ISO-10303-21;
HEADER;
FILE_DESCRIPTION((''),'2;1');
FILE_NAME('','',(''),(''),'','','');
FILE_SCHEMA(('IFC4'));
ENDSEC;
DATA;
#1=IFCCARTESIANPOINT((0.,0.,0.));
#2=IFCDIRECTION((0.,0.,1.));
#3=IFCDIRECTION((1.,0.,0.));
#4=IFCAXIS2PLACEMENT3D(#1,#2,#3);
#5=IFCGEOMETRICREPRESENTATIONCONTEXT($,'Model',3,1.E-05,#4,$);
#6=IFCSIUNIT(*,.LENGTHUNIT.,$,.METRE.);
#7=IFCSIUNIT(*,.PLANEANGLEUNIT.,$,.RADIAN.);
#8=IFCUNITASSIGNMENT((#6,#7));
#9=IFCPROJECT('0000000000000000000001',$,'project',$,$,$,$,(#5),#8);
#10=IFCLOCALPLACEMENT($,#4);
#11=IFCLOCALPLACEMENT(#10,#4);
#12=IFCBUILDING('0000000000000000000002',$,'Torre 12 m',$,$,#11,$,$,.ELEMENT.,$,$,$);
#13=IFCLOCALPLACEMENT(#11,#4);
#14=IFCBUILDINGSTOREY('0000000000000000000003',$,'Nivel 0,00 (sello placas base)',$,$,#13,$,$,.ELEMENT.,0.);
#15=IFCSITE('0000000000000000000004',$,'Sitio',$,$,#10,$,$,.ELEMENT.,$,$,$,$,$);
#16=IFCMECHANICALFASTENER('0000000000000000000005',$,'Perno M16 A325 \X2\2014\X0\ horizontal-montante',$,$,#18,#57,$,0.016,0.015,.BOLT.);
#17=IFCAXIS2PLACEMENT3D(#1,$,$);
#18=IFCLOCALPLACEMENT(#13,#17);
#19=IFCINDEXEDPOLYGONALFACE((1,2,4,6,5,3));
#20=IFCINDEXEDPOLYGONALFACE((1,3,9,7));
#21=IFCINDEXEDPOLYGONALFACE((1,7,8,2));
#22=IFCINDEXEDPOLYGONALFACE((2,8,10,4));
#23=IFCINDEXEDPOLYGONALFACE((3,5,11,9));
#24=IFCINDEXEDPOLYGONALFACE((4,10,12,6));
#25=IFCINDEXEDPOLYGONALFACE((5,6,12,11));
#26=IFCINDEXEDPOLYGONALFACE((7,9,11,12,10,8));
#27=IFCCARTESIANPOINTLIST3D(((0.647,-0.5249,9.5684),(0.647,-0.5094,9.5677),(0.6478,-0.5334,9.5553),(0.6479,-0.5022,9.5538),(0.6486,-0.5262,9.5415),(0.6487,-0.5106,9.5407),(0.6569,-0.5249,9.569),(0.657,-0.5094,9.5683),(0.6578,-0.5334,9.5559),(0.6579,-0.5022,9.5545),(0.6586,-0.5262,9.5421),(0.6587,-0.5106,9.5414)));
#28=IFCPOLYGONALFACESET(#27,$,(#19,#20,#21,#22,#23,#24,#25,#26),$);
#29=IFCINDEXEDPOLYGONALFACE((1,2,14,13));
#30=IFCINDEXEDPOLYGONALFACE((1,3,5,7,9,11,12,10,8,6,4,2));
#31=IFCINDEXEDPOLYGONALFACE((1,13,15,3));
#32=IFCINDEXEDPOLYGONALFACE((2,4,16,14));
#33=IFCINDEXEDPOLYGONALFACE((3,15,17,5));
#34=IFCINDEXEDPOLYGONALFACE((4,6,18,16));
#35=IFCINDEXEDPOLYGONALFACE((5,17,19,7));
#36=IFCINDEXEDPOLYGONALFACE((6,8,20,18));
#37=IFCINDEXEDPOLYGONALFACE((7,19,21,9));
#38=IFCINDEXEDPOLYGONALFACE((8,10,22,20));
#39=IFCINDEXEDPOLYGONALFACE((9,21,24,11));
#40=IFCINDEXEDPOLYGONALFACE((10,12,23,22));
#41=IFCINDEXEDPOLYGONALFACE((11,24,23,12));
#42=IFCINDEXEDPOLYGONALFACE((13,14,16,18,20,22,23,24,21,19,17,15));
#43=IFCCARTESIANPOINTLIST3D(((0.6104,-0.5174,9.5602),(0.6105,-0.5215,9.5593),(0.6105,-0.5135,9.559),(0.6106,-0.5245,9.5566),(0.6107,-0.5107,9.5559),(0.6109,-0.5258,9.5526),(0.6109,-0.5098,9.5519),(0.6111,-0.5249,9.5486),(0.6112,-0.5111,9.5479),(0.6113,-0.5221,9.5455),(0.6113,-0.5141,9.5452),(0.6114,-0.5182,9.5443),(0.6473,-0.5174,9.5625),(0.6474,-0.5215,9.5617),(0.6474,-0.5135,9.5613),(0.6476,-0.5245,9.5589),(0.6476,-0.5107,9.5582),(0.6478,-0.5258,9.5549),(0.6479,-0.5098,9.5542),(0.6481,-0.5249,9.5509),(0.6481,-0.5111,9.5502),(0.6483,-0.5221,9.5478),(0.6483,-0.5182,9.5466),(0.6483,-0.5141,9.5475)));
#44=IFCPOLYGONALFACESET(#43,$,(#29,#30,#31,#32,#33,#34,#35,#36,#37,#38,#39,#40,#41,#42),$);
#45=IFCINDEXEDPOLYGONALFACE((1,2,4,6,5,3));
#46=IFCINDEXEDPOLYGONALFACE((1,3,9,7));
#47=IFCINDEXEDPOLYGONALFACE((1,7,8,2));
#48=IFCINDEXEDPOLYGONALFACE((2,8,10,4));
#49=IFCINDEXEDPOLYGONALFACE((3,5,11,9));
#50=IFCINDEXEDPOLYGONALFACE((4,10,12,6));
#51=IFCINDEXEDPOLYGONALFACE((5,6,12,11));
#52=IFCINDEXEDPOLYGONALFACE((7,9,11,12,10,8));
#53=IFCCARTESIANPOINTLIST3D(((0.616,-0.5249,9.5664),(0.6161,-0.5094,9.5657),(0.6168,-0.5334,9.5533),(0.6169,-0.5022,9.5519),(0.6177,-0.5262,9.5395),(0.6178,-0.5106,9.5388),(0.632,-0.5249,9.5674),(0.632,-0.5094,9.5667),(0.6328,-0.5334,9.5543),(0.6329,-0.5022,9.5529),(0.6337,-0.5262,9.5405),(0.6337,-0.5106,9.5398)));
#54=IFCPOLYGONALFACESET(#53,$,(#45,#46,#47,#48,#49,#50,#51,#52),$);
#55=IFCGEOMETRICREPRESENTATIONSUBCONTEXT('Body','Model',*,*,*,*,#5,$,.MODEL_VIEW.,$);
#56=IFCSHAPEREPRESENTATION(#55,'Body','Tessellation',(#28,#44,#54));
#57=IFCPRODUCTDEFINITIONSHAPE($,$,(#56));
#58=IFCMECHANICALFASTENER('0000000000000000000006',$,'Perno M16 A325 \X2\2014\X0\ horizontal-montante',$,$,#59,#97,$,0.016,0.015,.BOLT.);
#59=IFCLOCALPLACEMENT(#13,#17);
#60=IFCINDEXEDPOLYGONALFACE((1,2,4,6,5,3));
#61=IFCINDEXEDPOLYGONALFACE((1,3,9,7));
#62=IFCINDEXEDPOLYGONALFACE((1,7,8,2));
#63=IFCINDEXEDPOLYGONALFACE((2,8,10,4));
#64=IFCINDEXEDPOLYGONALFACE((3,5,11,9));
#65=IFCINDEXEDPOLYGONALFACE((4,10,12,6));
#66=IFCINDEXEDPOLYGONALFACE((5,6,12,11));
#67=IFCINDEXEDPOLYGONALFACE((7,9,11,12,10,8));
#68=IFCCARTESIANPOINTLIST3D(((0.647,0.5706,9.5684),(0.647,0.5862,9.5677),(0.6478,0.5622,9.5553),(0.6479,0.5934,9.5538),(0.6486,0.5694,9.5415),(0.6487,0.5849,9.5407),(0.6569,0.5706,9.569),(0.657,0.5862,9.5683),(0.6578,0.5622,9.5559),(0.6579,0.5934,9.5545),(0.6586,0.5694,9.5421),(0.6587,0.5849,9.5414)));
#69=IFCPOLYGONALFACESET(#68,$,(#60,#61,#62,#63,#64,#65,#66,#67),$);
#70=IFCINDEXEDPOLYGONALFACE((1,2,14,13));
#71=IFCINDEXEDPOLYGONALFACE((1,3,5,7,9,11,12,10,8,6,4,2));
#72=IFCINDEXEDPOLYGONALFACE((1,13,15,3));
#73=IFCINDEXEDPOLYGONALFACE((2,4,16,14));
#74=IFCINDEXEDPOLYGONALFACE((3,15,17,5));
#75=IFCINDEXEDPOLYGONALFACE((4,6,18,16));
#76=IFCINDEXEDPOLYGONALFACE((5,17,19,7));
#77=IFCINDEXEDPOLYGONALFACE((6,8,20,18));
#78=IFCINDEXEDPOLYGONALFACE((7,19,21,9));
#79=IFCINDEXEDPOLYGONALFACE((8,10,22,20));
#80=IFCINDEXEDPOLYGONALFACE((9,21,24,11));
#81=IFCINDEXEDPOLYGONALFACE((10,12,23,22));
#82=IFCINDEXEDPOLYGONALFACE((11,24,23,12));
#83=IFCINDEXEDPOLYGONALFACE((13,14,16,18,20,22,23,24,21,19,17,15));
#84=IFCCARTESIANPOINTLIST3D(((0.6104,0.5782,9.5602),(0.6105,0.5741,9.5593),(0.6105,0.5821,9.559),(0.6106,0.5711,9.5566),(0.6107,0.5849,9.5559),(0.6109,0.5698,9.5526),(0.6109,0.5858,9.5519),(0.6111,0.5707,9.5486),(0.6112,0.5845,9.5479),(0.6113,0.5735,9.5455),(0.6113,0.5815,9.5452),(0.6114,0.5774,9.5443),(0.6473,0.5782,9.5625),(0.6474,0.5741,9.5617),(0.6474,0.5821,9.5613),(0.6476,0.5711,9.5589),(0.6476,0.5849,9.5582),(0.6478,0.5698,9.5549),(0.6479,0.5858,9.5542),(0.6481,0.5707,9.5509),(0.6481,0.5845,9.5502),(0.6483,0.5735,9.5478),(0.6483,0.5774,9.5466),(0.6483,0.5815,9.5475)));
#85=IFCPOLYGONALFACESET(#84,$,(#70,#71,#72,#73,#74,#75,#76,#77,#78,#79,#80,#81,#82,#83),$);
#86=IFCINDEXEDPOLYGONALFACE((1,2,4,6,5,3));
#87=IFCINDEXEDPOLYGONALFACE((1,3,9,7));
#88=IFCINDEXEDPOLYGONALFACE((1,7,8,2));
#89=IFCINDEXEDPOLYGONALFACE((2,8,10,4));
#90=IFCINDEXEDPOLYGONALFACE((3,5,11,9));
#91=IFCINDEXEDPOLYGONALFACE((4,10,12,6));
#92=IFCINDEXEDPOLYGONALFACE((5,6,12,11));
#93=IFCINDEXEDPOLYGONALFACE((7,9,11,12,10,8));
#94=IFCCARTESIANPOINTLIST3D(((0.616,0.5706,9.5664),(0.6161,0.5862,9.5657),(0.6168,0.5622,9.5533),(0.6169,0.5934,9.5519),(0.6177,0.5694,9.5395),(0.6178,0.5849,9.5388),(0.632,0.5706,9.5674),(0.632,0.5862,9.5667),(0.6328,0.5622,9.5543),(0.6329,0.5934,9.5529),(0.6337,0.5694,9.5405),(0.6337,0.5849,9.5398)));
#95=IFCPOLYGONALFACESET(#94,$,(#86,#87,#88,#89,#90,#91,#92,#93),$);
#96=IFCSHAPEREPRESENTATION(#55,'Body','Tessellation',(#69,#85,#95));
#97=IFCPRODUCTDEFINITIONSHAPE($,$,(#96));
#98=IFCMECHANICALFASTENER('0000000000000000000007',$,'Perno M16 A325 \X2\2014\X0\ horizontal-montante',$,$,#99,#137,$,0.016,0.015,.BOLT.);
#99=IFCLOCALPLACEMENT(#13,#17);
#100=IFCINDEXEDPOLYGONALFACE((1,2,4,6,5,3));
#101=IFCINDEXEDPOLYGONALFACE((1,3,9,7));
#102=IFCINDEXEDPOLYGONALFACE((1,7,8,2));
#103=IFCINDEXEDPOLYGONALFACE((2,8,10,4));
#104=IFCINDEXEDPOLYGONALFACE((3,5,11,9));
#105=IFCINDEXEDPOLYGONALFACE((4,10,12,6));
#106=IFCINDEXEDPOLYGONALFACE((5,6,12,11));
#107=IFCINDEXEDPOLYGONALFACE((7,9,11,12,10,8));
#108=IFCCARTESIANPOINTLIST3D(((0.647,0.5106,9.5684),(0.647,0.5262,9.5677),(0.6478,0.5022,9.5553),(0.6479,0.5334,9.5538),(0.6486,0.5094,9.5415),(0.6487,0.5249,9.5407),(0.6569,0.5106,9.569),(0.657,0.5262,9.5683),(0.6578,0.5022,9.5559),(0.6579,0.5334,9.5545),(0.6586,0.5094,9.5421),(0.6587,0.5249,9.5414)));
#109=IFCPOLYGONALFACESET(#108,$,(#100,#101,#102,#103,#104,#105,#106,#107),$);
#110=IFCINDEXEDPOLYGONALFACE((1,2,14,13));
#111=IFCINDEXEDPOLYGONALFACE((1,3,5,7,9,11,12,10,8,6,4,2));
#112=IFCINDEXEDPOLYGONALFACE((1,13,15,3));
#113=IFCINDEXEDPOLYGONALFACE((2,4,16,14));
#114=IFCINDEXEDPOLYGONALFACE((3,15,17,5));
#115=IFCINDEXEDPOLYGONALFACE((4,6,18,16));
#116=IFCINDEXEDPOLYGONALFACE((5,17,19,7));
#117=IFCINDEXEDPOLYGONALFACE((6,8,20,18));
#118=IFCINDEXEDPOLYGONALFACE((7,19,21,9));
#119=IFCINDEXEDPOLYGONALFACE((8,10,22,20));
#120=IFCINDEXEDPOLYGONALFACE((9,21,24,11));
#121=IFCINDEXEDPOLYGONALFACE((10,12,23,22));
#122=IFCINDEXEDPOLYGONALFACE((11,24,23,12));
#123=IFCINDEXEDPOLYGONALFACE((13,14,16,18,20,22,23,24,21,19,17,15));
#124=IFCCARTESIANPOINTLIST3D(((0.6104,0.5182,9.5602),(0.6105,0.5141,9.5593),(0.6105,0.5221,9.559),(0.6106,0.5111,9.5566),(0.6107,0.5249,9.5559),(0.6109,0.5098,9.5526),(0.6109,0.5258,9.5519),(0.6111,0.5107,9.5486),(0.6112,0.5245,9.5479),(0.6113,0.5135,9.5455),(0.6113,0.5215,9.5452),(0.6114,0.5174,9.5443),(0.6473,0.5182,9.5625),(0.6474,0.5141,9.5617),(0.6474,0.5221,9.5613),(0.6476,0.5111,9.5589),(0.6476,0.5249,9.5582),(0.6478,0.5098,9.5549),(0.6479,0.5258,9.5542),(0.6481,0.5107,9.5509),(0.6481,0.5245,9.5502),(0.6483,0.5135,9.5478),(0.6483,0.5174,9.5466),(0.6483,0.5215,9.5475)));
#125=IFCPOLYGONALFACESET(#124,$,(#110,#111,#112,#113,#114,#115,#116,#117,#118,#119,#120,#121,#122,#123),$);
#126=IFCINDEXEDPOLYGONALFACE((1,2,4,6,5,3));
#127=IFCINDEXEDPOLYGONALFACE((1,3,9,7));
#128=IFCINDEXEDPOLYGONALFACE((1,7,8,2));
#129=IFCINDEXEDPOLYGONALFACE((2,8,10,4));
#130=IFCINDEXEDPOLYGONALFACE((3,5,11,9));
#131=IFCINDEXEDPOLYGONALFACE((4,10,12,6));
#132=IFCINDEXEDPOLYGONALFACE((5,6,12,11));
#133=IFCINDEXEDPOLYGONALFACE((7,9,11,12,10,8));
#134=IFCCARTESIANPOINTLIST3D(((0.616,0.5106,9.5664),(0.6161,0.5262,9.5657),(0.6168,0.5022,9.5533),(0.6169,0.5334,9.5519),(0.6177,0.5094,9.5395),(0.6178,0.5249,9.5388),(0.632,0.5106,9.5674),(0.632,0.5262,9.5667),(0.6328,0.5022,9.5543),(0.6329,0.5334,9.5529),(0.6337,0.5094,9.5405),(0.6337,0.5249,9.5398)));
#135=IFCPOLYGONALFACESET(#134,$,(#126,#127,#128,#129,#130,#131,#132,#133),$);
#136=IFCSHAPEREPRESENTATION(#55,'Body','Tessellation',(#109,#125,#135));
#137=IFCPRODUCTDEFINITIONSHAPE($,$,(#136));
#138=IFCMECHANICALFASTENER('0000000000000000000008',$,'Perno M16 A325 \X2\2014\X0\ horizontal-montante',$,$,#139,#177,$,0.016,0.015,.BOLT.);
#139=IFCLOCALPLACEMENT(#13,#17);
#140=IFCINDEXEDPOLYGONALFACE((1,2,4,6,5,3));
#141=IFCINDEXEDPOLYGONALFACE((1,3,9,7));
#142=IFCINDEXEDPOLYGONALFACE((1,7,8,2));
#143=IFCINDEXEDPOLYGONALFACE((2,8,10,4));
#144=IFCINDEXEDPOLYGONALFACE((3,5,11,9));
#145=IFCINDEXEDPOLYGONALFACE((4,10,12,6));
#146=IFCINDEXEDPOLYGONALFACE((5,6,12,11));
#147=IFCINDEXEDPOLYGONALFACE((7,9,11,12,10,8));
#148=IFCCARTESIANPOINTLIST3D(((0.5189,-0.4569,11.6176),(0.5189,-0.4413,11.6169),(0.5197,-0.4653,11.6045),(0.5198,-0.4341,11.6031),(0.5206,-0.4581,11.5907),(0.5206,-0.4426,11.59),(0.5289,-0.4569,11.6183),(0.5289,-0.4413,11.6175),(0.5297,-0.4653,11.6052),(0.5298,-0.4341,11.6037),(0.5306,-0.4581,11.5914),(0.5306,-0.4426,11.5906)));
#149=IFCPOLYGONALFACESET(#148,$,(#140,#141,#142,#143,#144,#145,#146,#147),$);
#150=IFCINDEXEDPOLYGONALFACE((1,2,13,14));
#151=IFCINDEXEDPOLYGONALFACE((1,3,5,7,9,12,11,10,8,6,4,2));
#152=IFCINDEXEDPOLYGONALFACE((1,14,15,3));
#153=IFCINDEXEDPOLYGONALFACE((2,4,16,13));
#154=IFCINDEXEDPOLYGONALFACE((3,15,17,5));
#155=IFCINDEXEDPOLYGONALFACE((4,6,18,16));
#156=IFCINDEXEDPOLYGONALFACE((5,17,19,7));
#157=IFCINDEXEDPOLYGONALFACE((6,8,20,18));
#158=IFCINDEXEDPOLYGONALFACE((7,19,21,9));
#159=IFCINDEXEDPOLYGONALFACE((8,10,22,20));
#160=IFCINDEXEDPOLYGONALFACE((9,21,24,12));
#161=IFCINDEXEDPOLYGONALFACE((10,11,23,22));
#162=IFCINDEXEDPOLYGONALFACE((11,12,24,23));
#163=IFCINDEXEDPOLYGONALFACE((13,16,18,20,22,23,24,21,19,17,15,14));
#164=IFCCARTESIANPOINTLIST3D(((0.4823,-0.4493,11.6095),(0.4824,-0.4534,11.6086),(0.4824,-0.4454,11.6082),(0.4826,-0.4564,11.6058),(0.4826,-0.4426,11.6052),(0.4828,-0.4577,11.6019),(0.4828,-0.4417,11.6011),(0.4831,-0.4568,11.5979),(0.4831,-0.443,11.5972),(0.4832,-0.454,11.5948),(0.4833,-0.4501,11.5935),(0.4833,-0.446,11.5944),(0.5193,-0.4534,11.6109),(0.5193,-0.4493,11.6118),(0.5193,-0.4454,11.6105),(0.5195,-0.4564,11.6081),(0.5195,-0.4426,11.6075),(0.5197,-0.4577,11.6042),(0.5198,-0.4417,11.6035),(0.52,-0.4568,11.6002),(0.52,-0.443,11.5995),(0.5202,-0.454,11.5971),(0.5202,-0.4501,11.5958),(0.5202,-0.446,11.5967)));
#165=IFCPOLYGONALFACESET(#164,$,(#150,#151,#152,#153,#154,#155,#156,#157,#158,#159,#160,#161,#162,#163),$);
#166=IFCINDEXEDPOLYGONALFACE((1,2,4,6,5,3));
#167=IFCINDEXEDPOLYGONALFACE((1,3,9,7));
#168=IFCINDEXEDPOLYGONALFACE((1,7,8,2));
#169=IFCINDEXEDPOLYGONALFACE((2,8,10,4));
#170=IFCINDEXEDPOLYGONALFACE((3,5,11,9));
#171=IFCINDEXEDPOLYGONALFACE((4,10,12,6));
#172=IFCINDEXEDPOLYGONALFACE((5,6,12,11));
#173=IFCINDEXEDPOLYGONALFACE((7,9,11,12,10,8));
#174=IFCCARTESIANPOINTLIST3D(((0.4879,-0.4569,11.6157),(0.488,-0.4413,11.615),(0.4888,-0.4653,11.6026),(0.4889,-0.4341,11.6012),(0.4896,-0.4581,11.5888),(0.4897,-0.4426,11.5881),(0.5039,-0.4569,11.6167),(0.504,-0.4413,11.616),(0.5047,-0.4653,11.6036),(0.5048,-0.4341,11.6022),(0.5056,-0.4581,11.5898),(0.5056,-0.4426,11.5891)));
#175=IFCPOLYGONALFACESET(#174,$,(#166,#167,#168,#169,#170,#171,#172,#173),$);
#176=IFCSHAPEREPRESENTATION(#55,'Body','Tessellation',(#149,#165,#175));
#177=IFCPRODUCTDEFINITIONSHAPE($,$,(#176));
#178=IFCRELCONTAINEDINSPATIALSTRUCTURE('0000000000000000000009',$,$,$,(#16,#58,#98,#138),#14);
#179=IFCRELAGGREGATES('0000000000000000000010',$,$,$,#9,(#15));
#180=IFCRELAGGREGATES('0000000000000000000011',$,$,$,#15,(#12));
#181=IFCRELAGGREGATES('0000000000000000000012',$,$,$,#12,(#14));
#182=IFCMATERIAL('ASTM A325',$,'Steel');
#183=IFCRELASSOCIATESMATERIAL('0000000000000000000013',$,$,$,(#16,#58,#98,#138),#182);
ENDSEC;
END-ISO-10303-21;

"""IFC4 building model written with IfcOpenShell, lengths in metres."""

from ifc_helpers import new_model, si_unit, frame, origin_with_axes, place, context, subcontext, project, spatial, polyline, outline, extrude, material, element, save


model = new_model("IFC4")

# Units and contexts
model_context = context("Model", 3, precision=1e-05, world=origin_with_axes())
body_context = subcontext(model_context, "Body", "Model", "MODEL_VIEW")
ifc_project = project(units=[si_unit("LENGTHUNIT", "METRE"), si_unit("PLANEANGLEUNIT", "RADIAN")], contexts=[model_context])

# Site, building, storey
site_placement = place(None, origin_with_axes())
site = spatial("IfcSite", under=ifc_project, at=site_placement, Name="Sitio", CompositionType="ELEMENT")
building_placement = place(site_placement, origin_with_axes())
building = spatial("IfcBuilding", under=site, at=building_placement, Name="Torre 12 m", CompositionType="ELEMENT")
storey_placement = place(building_placement, origin_with_axes())
storey = spatial("IfcBuildingStorey", under=building, at=storey_placement, Name="Nivel 0,00 (sello placas base)", CompositionType="ELEMENT", Elevation=0.0)

# Shared definitions
placement = place(storey_placement, origin_with_axes())

# Mechanical fasteners
ifc_material_1 = material(Name="ASTM A325", Category="Steel")
element("IfcMechanicalFastener", 1, at=placement, inside=storey, material=ifc_material_1, Name="Perno M16 A325 — horizontal-montante", NominalDiameter=0.016, NominalLength=0.015, PredefinedType="BOLT", context=body_context, shape_type="SweptSolid", body=[
    extrude(outline(polyline([(0.0135, 0.0078), (0.0, 0.0156), (-0.0135, 0.0078), (-0.0135, -0.0078), (0.0, -0.0156), (0.0135, -0.0078), (0.0135, 0.0078)])), frame((0.6578, -0.5178, 9.5552), z_axis=(-0.998053, 0.0, -0.062378), x_axis=(0.033672, 0.841794, -0.538748)), (0.0, 0.0, 1.0), 0.01),
    extrude(outline(polyline([(0.008, 0.0), (0.0069, 0.004), (0.004, 0.0069), (0.0, 0.008), (-0.004, 0.0069), (-0.0069, 0.004), (-0.008, 0.0), (-0.0069, -0.004), (-0.004, -0.0069), (0.0, -0.008), (0.004, -0.0069), (0.0069, -0.004), (0.008, 0.0)])), frame((0.6478, -0.5178, 9.5546), z_axis=(-0.998053, 0.0, -0.062378), x_axis=(0.033672, 0.841794, -0.538748)), (0.0, 0.0, 1.0), 0.037),
    extrude(outline(polyline([(0.0135, 0.0078), (0.0, 0.0156), (-0.0135, 0.0078), (-0.0135, -0.0078), (0.0, -0.0156), (0.0135, -0.0078), (0.0135, 0.0078)])), frame((0.6329, -0.5178, 9.5536), z_axis=(-0.998053, 0.0, -0.062378), x_axis=(0.033672, 0.841794, -0.538748)), (0.0, 0.0, 1.0), 0.016),
])
element("IfcMechanicalFastener", 2, at=placement, inside=storey, material=ifc_material_1, Name="Perno M16 A325 — horizontal-montante", NominalDiameter=0.016, NominalLength=0.015, PredefinedType="BOLT", context=body_context, shape_type="SweptSolid", body=[
    extrude(outline(polyline([(0.0135, 0.0078), (0.0, 0.0156), (-0.0135, 0.0078), (-0.0135, -0.0078), (0.0, -0.0156), (0.0135, -0.0078), (0.0135, 0.0078)])), frame((0.6578, 0.5778, 9.5552), z_axis=(-0.998053, 0.0, -0.062378), x_axis=(0.033672, 0.841794, -0.538748)), (0.0, 0.0, 1.0), 0.01),
    extrude(outline(polyline([(0.008, 0.0), (0.0069, 0.004), (0.004, 0.0069), (0.0, 0.008), (-0.004, 0.0069), (-0.0069, 0.004), (-0.008, 0.0), (-0.0069, -0.004), (-0.004, -0.0069), (0.0, -0.008), (0.004, -0.0069), (0.0069, -0.004), (0.008, 0.0)])), frame((0.6478, 0.5778, 9.5546), z_axis=(-0.998053, 0.0, -0.062378), x_axis=(0.033672, 0.841794, -0.538748)), (0.0, 0.0, 1.0), 0.037),
    extrude(outline(polyline([(0.0135, 0.0078), (0.0, 0.0156), (-0.0135, 0.0078), (-0.0135, -0.0078), (0.0, -0.0156), (0.0135, -0.0078), (0.0135, 0.0078)])), frame((0.6329, 0.5778, 9.5536), z_axis=(-0.998053, 0.0, -0.062378), x_axis=(0.033672, 0.841794, -0.538748)), (0.0, 0.0, 1.0), 0.016),
])
element("IfcMechanicalFastener", 3, at=placement, inside=storey, material=ifc_material_1, Name="Perno M16 A325 — horizontal-montante", NominalDiameter=0.016, NominalLength=0.015, PredefinedType="BOLT", context=body_context, shape_type="SweptSolid", body=[
    extrude(outline(polyline([(0.0135, 0.0078), (0.0, 0.0156), (-0.0135, 0.0078), (-0.0135, -0.0078), (0.0, -0.0156), (0.0135, -0.0078), (0.0135, 0.0078)])), frame((0.6578, 0.5178, 9.5552), z_axis=(-0.998053, 0.0, -0.062378), x_axis=(0.033672, 0.841794, -0.538748)), (0.0, 0.0, 1.0), 0.01),
    extrude(outline(polyline([(0.008, 0.0), (0.0069, 0.004), (0.004, 0.0069), (0.0, 0.008), (-0.004, 0.0069), (-0.0069, 0.004), (-0.008, 0.0), (-0.0069, -0.004), (-0.004, -0.0069), (0.0, -0.008), (0.004, -0.0069), (0.0069, -0.004), (0.008, 0.0)])), frame((0.6478, 0.5178, 9.5546), z_axis=(-0.998053, 0.0, -0.062378), x_axis=(0.033672, 0.841794, -0.538748)), (0.0, 0.0, 1.0), 0.037),
    extrude(outline(polyline([(0.0135, 0.0078), (0.0, 0.0156), (-0.0135, 0.0078), (-0.0135, -0.0078), (0.0, -0.0156), (0.0135, -0.0078), (0.0135, 0.0078)])), frame((0.6329, 0.5178, 9.5536), z_axis=(-0.998053, 0.0, -0.062378), x_axis=(0.033672, 0.841794, -0.538748)), (0.0, 0.0, 1.0), 0.016),
])
element("IfcMechanicalFastener", 4, at=placement, inside=storey, material=ifc_material_1, Name="Perno M16 A325 — horizontal-montante", NominalDiameter=0.016, NominalLength=0.015, PredefinedType="BOLT", context=body_context, shape_type="SweptSolid", body=[
    extrude(outline(polyline([(0.0135, 0.0078), (0.0, 0.0156), (-0.0135, 0.0078), (-0.0135, -0.0078), (0.0, -0.0156), (0.0135, -0.0078), (0.0135, 0.0078)])), frame((0.5297, -0.4497, 11.6044), z_axis=(-0.998053, 0.0, -0.062378), x_axis=(0.033672, 0.841794, -0.538748)), (0.0, 0.0, 1.0), 0.01),
    extrude(outline(polyline([(0.008, 0.0), (0.0069, 0.004), (0.004, 0.0069), (0.0, 0.008), (-0.004, 0.0069), (-0.0069, 0.004), (-0.008, 0.0), (-0.0069, -0.004), (-0.004, -0.0069), (0.0, -0.008), (0.004, -0.0069), (0.0069, -0.004), (0.008, 0.0)])), frame((0.5198, -0.4497, 11.6038), z_axis=(-0.998053, 0.0, -0.062378), x_axis=(0.033672, 0.841794, -0.538748)), (0.0, 0.0, 1.0), 0.037),
    extrude(outline(polyline([(0.0135, 0.0078), (0.0, 0.0156), (-0.0135, 0.0078), (-0.0135, -0.0078), (0.0, -0.0156), (0.0135, -0.0078), (0.0135, 0.0078)])), frame((0.5048, -0.4497, 11.6029), z_axis=(-0.998053, 0.0, -0.062378), x_axis=(0.033672, 0.841794, -0.538748)), (0.0, 0.0, 1.0), 0.016),
])

save(model, "model.ifc")
